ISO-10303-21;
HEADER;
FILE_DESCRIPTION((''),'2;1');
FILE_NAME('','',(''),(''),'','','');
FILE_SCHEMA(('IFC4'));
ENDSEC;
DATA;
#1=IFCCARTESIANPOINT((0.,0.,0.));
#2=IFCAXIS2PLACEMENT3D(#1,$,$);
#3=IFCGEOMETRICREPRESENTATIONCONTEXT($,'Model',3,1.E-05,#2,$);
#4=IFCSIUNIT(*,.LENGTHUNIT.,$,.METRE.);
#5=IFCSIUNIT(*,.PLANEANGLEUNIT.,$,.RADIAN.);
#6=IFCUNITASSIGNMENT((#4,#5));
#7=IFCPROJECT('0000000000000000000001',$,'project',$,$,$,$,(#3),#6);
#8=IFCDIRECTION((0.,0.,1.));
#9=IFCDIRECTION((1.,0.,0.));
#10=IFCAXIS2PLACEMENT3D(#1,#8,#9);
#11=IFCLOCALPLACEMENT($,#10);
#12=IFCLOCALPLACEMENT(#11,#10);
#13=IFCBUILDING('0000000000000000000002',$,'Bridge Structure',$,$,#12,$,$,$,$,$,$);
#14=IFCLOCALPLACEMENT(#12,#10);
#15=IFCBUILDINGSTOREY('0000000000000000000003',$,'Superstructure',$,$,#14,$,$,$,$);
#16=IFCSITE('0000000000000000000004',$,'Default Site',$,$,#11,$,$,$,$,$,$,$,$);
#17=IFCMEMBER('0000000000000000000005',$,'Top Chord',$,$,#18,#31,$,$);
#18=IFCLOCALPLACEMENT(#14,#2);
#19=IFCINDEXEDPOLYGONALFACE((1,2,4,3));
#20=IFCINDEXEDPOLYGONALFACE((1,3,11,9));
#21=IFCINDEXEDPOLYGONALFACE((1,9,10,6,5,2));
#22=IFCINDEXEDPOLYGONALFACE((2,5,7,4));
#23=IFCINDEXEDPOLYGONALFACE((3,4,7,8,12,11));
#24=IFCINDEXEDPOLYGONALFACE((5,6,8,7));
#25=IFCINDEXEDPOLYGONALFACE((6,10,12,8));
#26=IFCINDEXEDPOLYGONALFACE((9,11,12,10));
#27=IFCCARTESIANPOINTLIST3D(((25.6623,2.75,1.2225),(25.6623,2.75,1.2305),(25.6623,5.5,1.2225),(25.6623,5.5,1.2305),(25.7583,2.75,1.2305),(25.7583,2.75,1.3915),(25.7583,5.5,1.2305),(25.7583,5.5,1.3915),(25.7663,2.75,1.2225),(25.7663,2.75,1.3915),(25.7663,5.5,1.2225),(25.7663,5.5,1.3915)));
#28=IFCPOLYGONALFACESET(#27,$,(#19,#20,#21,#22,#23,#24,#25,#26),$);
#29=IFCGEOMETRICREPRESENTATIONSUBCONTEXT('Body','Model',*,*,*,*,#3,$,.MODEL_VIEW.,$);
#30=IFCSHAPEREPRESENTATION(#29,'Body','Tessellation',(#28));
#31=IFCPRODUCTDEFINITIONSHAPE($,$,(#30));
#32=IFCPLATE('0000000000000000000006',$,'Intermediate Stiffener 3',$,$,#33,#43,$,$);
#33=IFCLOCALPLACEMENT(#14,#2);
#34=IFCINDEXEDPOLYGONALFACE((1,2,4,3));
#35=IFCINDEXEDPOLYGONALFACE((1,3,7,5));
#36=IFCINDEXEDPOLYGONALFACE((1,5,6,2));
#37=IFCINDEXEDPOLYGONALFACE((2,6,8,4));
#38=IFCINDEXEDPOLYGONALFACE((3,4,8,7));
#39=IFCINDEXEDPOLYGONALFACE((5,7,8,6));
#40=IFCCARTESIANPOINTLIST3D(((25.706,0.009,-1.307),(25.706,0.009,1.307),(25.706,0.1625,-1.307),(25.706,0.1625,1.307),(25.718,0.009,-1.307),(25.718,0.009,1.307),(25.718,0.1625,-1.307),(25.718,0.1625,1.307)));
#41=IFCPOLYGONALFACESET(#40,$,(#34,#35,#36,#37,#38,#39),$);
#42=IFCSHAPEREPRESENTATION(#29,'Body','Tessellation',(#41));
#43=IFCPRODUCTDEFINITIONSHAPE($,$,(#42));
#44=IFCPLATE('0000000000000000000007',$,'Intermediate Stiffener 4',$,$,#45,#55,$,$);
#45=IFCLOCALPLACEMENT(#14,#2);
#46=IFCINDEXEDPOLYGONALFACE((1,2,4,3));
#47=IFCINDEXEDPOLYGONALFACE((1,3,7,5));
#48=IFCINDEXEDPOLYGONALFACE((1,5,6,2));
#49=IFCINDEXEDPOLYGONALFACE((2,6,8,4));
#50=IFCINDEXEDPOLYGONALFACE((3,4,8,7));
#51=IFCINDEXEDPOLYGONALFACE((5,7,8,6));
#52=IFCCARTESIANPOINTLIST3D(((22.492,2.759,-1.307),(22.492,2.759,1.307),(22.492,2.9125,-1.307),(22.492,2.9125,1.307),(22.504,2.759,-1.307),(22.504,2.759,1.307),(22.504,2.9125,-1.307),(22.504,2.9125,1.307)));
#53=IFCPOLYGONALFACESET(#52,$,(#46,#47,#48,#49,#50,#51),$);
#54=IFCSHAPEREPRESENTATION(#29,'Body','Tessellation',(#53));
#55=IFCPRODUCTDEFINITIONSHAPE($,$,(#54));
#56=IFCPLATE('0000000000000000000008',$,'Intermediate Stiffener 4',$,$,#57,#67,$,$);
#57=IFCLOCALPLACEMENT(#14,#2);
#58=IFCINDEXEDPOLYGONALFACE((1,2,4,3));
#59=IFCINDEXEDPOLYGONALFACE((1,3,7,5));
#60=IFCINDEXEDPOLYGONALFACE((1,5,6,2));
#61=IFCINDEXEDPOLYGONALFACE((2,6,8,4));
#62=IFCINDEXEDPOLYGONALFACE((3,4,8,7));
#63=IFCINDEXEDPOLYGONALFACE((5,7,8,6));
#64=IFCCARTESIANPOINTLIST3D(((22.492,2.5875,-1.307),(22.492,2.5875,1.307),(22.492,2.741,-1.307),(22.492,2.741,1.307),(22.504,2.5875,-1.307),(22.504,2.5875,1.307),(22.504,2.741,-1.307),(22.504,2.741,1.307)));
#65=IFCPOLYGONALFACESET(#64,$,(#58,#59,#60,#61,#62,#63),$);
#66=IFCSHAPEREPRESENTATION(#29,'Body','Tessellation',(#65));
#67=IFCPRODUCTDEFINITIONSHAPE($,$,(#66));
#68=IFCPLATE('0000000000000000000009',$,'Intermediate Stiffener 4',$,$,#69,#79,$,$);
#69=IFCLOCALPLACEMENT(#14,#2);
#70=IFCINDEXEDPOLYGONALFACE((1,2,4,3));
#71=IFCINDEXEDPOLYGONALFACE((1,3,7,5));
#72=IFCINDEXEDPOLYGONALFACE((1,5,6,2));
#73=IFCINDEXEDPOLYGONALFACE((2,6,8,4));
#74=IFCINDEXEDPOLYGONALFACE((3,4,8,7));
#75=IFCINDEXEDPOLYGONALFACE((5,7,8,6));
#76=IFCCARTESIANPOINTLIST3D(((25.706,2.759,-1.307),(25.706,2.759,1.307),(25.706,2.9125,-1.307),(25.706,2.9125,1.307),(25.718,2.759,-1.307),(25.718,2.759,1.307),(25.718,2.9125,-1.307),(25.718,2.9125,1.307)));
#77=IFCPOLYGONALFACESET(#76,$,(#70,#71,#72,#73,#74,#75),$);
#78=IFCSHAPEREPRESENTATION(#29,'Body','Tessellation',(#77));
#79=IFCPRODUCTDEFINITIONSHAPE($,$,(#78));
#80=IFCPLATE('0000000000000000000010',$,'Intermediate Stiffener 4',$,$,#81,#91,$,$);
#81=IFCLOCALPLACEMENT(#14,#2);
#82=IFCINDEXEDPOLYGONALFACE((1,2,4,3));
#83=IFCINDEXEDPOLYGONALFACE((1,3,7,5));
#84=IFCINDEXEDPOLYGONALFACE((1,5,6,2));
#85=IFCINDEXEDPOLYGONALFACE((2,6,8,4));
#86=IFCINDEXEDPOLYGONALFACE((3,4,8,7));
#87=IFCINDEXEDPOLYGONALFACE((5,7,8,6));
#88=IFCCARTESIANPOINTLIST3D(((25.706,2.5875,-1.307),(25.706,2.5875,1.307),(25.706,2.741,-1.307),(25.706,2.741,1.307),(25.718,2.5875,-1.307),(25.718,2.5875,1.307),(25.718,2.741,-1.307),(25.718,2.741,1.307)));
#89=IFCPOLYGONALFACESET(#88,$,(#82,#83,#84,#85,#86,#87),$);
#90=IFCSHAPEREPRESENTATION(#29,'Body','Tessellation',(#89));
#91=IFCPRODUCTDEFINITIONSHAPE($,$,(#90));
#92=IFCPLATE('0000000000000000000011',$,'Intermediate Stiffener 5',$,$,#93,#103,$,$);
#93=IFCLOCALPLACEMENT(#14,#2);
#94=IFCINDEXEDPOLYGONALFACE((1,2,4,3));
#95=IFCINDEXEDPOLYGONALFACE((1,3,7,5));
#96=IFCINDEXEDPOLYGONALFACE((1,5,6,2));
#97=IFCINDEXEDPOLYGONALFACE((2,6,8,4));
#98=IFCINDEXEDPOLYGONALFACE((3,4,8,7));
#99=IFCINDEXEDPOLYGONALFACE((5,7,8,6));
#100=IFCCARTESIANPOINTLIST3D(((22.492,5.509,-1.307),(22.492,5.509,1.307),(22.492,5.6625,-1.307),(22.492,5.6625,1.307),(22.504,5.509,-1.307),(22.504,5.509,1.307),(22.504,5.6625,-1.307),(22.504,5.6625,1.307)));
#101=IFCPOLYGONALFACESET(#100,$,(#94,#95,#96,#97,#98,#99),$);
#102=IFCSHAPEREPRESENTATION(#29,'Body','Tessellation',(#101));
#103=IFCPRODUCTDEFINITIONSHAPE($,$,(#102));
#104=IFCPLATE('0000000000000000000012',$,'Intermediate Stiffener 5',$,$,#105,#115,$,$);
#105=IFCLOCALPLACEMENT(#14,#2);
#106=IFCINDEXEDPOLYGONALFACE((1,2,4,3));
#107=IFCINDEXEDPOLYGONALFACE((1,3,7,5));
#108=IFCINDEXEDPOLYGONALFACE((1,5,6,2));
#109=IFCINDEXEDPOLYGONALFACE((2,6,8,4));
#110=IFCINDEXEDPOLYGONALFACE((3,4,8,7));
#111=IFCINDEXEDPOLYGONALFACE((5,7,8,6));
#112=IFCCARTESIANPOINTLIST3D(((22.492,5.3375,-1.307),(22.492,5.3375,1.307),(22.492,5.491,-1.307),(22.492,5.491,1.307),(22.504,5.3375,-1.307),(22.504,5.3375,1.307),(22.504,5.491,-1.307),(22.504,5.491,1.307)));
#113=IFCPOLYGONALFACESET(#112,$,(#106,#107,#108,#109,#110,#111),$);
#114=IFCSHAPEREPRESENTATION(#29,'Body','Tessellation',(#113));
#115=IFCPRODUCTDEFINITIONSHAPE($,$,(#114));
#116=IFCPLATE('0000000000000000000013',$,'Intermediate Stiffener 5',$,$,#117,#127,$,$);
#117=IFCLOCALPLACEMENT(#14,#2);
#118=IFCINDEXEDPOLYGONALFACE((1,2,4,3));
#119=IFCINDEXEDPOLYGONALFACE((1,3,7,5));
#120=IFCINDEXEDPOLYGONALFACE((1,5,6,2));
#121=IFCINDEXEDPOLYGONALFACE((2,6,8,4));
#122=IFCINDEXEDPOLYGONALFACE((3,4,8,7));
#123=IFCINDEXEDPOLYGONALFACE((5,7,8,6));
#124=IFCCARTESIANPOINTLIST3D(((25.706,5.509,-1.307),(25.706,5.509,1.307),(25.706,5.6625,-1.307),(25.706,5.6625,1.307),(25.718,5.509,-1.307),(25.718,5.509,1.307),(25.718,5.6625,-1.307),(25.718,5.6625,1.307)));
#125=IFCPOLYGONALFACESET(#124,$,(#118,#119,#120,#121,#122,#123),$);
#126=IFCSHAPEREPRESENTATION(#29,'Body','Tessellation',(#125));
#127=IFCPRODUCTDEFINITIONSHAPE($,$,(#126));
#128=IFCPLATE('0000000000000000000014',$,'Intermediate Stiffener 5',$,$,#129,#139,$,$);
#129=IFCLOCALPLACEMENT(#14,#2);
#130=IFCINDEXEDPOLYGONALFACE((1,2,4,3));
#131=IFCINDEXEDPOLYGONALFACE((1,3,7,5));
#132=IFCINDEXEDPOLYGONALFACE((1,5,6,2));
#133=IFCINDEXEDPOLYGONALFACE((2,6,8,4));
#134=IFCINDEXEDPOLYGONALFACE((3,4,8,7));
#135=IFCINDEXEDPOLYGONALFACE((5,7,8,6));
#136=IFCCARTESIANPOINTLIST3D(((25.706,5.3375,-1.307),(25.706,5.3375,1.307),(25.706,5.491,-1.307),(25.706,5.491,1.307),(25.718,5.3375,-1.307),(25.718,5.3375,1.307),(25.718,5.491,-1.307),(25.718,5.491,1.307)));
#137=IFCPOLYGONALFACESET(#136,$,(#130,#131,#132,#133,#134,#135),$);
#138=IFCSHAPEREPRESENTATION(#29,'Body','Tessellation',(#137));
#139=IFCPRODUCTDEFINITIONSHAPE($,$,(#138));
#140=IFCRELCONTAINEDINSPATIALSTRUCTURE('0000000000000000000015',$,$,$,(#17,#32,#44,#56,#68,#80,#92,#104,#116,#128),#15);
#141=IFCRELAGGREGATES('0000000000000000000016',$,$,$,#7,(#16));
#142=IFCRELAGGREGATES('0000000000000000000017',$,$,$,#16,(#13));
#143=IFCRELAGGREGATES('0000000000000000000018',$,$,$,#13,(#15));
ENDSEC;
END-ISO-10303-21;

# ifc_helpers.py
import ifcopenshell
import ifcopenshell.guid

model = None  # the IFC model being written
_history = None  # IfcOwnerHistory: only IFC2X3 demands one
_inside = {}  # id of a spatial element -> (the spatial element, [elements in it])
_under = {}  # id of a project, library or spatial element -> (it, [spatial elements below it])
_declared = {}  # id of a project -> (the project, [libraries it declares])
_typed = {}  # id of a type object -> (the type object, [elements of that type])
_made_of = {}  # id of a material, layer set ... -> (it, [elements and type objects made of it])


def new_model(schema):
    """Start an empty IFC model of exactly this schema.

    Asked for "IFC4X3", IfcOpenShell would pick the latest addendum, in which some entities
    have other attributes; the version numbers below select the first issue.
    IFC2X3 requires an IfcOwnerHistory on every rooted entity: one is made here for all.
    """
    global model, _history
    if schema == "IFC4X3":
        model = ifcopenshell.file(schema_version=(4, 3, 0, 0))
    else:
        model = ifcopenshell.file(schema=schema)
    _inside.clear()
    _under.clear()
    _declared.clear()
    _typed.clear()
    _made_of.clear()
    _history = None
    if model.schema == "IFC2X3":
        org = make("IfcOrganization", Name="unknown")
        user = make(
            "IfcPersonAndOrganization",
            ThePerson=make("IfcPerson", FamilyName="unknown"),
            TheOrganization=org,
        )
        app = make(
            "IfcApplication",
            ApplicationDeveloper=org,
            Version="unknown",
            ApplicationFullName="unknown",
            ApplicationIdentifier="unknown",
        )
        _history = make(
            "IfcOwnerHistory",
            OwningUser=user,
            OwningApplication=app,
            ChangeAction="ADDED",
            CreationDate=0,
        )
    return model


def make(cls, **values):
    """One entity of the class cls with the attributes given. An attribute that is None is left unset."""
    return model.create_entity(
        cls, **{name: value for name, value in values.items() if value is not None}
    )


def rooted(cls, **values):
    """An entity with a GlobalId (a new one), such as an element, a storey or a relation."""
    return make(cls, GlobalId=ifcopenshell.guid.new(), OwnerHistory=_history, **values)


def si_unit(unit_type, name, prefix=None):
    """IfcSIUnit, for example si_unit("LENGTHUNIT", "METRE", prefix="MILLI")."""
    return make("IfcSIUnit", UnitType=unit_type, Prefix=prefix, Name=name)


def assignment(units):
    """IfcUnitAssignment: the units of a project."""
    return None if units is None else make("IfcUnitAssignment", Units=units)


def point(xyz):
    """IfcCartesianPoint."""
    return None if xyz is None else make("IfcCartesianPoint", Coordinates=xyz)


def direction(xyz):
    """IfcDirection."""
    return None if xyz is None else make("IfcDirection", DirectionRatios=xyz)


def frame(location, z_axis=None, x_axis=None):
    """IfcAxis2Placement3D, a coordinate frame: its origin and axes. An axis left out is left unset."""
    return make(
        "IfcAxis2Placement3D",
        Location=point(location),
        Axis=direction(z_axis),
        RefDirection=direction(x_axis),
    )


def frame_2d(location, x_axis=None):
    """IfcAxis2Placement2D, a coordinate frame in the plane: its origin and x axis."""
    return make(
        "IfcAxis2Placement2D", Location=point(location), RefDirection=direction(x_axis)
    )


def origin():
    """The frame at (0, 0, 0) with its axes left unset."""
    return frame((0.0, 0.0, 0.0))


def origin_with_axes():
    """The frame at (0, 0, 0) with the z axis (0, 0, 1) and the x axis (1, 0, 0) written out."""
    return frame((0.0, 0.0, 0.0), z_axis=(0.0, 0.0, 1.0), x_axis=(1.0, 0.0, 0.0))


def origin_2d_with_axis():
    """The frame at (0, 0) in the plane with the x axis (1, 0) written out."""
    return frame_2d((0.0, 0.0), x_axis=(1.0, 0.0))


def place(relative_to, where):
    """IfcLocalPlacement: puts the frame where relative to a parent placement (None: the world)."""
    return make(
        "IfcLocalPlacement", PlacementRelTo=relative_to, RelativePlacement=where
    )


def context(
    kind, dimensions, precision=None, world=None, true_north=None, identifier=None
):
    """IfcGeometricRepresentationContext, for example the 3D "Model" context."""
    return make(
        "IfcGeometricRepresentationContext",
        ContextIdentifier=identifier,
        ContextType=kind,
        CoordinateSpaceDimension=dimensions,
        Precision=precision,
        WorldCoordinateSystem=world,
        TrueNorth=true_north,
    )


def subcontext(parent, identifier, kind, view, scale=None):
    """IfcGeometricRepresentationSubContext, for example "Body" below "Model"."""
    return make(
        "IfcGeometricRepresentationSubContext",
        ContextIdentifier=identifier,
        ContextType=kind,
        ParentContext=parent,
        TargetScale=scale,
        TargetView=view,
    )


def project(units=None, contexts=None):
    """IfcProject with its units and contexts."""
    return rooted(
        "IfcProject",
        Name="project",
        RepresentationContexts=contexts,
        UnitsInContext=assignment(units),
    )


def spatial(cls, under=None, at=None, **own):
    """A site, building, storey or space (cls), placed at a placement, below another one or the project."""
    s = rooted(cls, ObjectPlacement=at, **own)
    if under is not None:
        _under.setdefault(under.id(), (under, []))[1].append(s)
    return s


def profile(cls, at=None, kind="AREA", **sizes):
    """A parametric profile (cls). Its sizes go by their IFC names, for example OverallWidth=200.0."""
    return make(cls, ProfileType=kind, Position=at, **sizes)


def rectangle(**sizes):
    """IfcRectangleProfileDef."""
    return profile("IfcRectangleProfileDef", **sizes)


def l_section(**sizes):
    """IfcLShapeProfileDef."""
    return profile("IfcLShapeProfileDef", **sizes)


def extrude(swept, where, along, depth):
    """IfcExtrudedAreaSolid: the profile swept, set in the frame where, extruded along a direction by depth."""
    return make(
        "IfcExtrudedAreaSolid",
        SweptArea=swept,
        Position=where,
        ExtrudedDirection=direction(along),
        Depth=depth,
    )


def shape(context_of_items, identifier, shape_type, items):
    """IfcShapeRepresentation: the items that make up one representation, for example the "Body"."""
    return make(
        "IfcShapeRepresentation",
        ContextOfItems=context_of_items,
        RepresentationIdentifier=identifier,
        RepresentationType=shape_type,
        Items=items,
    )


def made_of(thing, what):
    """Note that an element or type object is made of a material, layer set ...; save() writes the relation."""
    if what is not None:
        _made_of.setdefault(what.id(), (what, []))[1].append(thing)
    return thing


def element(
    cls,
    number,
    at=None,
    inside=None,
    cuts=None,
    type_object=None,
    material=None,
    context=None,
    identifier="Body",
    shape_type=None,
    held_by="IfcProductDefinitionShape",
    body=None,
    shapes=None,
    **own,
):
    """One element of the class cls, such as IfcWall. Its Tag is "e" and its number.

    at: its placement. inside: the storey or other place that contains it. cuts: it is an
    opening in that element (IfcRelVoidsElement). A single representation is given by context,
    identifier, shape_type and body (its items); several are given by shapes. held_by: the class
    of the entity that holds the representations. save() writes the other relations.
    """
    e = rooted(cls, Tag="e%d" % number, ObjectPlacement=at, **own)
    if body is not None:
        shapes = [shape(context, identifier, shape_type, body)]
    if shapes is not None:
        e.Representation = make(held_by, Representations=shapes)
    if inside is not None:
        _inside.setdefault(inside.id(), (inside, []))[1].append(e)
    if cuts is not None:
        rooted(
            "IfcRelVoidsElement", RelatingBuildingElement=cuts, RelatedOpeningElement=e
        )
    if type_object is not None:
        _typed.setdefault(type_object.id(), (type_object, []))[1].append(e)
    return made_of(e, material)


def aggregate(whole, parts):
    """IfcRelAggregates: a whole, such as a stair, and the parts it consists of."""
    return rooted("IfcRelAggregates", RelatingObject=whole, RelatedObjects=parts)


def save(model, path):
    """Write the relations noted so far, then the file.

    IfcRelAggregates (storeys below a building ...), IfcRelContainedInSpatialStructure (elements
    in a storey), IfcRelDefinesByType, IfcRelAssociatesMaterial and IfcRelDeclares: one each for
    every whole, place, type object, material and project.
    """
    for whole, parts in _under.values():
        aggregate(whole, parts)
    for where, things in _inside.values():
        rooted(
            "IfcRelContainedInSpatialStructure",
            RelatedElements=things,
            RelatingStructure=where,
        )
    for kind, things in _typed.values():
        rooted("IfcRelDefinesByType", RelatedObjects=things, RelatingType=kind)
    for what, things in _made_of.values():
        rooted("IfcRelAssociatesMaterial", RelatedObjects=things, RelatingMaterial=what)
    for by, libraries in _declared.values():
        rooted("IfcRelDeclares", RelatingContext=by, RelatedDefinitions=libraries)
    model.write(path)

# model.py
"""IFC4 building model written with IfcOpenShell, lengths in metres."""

from ifc_helpers import new_model, si_unit, frame, origin, origin_with_axes, origin_2d_with_axis, place, context, subcontext, project, spatial, rectangle, l_section, extrude, element, save


model = new_model("IFC4")

# Units and contexts
model_context = context("Model", 3, precision=1e-05, world=origin())
body_context = subcontext(model_context, "Body", "Model", "MODEL_VIEW")
ifc_project = project(units=[si_unit("LENGTHUNIT", "METRE"), si_unit("PLANEANGLEUNIT", "RADIAN")], contexts=[model_context])

# Site, building, storey
site_placement = place(None, origin_with_axes())
site = spatial("IfcSite", under=ifc_project, at=site_placement, Name="Default Site")
building_placement = place(site_placement, origin_with_axes())
building = spatial("IfcBuilding", under=site, at=building_placement, Name="Bridge Structure")
storey_placement = place(building_placement, origin_with_axes())
storey = spatial("IfcBuildingStorey", under=building, at=storey_placement, Name="Superstructure")

# Member
for number, where, z_axis, x_axis, name in (
    (1, (25.7143, 2.75, 1.307), (0.0, 1.0, 0.0), (-1.0, 0.0, 0.0), "Top Chord"),
):
    element("IfcMember", number, at=place(storey_placement, frame(where, z_axis=z_axis, x_axis=x_axis)), inside=storey, Name=name, context=body_context, shape_type="SweptSolid", body=[
        extrude(l_section(Depth=0.169, Width=0.104, Thickness=0.008, at=origin_2d_with_axis()), origin_with_axes(), (0.0, 0.0, 1.0), 2.75),
    ])

# Plates
for number, where, z_axis, x_axis, name in (
    (2, (25.712, 0.0858, -1.307), (0.0, 0.0, 1.0), (1.0, 0.0, 0.0), "Intermediate Stiffener 3"),
    (3, (22.498, 2.8357, -1.307), (0.0, 0.0, 1.0), (1.0, 0.0, 0.0), "Intermediate Stiffener 4"),
    (4, (22.498, 2.6643, -1.307), (0.0, 0.0, 1.0), (1.0, 0.0, 0.0), "Intermediate Stiffener 4"),
    (5, (25.712, 2.8357, -1.307), (0.0, 0.0, 1.0), (1.0, 0.0, 0.0), "Intermediate Stiffener 4"),
    (6, (25.712, 2.6643, -1.307), (0.0, 0.0, 1.0), (1.0, 0.0, 0.0), "Intermediate Stiffener 4"),
    (7, (22.498, 5.5857, -1.307), (0.0, 0.0, 1.0), (1.0, 0.0, 0.0), "Intermediate Stiffener 5"),
    (8, (22.498, 5.4143, -1.307), (0.0, 0.0, 1.0), (1.0, 0.0, 0.0), "Intermediate Stiffener 5"),
    (9, (25.712, 5.5857, -1.307), (0.0, 0.0, 1.0), (1.0, 0.0, 0.0), "Intermediate Stiffener 5"),
    (10, (25.712, 5.4143, -1.307), (0.0, 0.0, 1.0), (1.0, 0.0, 0.0), "Intermediate Stiffener 5"),
):
    element("IfcPlate", number, at=place(storey_placement, frame(where, z_axis=z_axis, x_axis=x_axis)), inside=storey, Name=name, context=body_context, shape_type="SweptSolid", body=[
        extrude(rectangle(XDim=0.012, YDim=0.1535, at=origin_2d_with_axis()), origin_with_axes(), (0.0, 0.0, 1.0), 2.614),
    ])

save(model, "model.ifc")
